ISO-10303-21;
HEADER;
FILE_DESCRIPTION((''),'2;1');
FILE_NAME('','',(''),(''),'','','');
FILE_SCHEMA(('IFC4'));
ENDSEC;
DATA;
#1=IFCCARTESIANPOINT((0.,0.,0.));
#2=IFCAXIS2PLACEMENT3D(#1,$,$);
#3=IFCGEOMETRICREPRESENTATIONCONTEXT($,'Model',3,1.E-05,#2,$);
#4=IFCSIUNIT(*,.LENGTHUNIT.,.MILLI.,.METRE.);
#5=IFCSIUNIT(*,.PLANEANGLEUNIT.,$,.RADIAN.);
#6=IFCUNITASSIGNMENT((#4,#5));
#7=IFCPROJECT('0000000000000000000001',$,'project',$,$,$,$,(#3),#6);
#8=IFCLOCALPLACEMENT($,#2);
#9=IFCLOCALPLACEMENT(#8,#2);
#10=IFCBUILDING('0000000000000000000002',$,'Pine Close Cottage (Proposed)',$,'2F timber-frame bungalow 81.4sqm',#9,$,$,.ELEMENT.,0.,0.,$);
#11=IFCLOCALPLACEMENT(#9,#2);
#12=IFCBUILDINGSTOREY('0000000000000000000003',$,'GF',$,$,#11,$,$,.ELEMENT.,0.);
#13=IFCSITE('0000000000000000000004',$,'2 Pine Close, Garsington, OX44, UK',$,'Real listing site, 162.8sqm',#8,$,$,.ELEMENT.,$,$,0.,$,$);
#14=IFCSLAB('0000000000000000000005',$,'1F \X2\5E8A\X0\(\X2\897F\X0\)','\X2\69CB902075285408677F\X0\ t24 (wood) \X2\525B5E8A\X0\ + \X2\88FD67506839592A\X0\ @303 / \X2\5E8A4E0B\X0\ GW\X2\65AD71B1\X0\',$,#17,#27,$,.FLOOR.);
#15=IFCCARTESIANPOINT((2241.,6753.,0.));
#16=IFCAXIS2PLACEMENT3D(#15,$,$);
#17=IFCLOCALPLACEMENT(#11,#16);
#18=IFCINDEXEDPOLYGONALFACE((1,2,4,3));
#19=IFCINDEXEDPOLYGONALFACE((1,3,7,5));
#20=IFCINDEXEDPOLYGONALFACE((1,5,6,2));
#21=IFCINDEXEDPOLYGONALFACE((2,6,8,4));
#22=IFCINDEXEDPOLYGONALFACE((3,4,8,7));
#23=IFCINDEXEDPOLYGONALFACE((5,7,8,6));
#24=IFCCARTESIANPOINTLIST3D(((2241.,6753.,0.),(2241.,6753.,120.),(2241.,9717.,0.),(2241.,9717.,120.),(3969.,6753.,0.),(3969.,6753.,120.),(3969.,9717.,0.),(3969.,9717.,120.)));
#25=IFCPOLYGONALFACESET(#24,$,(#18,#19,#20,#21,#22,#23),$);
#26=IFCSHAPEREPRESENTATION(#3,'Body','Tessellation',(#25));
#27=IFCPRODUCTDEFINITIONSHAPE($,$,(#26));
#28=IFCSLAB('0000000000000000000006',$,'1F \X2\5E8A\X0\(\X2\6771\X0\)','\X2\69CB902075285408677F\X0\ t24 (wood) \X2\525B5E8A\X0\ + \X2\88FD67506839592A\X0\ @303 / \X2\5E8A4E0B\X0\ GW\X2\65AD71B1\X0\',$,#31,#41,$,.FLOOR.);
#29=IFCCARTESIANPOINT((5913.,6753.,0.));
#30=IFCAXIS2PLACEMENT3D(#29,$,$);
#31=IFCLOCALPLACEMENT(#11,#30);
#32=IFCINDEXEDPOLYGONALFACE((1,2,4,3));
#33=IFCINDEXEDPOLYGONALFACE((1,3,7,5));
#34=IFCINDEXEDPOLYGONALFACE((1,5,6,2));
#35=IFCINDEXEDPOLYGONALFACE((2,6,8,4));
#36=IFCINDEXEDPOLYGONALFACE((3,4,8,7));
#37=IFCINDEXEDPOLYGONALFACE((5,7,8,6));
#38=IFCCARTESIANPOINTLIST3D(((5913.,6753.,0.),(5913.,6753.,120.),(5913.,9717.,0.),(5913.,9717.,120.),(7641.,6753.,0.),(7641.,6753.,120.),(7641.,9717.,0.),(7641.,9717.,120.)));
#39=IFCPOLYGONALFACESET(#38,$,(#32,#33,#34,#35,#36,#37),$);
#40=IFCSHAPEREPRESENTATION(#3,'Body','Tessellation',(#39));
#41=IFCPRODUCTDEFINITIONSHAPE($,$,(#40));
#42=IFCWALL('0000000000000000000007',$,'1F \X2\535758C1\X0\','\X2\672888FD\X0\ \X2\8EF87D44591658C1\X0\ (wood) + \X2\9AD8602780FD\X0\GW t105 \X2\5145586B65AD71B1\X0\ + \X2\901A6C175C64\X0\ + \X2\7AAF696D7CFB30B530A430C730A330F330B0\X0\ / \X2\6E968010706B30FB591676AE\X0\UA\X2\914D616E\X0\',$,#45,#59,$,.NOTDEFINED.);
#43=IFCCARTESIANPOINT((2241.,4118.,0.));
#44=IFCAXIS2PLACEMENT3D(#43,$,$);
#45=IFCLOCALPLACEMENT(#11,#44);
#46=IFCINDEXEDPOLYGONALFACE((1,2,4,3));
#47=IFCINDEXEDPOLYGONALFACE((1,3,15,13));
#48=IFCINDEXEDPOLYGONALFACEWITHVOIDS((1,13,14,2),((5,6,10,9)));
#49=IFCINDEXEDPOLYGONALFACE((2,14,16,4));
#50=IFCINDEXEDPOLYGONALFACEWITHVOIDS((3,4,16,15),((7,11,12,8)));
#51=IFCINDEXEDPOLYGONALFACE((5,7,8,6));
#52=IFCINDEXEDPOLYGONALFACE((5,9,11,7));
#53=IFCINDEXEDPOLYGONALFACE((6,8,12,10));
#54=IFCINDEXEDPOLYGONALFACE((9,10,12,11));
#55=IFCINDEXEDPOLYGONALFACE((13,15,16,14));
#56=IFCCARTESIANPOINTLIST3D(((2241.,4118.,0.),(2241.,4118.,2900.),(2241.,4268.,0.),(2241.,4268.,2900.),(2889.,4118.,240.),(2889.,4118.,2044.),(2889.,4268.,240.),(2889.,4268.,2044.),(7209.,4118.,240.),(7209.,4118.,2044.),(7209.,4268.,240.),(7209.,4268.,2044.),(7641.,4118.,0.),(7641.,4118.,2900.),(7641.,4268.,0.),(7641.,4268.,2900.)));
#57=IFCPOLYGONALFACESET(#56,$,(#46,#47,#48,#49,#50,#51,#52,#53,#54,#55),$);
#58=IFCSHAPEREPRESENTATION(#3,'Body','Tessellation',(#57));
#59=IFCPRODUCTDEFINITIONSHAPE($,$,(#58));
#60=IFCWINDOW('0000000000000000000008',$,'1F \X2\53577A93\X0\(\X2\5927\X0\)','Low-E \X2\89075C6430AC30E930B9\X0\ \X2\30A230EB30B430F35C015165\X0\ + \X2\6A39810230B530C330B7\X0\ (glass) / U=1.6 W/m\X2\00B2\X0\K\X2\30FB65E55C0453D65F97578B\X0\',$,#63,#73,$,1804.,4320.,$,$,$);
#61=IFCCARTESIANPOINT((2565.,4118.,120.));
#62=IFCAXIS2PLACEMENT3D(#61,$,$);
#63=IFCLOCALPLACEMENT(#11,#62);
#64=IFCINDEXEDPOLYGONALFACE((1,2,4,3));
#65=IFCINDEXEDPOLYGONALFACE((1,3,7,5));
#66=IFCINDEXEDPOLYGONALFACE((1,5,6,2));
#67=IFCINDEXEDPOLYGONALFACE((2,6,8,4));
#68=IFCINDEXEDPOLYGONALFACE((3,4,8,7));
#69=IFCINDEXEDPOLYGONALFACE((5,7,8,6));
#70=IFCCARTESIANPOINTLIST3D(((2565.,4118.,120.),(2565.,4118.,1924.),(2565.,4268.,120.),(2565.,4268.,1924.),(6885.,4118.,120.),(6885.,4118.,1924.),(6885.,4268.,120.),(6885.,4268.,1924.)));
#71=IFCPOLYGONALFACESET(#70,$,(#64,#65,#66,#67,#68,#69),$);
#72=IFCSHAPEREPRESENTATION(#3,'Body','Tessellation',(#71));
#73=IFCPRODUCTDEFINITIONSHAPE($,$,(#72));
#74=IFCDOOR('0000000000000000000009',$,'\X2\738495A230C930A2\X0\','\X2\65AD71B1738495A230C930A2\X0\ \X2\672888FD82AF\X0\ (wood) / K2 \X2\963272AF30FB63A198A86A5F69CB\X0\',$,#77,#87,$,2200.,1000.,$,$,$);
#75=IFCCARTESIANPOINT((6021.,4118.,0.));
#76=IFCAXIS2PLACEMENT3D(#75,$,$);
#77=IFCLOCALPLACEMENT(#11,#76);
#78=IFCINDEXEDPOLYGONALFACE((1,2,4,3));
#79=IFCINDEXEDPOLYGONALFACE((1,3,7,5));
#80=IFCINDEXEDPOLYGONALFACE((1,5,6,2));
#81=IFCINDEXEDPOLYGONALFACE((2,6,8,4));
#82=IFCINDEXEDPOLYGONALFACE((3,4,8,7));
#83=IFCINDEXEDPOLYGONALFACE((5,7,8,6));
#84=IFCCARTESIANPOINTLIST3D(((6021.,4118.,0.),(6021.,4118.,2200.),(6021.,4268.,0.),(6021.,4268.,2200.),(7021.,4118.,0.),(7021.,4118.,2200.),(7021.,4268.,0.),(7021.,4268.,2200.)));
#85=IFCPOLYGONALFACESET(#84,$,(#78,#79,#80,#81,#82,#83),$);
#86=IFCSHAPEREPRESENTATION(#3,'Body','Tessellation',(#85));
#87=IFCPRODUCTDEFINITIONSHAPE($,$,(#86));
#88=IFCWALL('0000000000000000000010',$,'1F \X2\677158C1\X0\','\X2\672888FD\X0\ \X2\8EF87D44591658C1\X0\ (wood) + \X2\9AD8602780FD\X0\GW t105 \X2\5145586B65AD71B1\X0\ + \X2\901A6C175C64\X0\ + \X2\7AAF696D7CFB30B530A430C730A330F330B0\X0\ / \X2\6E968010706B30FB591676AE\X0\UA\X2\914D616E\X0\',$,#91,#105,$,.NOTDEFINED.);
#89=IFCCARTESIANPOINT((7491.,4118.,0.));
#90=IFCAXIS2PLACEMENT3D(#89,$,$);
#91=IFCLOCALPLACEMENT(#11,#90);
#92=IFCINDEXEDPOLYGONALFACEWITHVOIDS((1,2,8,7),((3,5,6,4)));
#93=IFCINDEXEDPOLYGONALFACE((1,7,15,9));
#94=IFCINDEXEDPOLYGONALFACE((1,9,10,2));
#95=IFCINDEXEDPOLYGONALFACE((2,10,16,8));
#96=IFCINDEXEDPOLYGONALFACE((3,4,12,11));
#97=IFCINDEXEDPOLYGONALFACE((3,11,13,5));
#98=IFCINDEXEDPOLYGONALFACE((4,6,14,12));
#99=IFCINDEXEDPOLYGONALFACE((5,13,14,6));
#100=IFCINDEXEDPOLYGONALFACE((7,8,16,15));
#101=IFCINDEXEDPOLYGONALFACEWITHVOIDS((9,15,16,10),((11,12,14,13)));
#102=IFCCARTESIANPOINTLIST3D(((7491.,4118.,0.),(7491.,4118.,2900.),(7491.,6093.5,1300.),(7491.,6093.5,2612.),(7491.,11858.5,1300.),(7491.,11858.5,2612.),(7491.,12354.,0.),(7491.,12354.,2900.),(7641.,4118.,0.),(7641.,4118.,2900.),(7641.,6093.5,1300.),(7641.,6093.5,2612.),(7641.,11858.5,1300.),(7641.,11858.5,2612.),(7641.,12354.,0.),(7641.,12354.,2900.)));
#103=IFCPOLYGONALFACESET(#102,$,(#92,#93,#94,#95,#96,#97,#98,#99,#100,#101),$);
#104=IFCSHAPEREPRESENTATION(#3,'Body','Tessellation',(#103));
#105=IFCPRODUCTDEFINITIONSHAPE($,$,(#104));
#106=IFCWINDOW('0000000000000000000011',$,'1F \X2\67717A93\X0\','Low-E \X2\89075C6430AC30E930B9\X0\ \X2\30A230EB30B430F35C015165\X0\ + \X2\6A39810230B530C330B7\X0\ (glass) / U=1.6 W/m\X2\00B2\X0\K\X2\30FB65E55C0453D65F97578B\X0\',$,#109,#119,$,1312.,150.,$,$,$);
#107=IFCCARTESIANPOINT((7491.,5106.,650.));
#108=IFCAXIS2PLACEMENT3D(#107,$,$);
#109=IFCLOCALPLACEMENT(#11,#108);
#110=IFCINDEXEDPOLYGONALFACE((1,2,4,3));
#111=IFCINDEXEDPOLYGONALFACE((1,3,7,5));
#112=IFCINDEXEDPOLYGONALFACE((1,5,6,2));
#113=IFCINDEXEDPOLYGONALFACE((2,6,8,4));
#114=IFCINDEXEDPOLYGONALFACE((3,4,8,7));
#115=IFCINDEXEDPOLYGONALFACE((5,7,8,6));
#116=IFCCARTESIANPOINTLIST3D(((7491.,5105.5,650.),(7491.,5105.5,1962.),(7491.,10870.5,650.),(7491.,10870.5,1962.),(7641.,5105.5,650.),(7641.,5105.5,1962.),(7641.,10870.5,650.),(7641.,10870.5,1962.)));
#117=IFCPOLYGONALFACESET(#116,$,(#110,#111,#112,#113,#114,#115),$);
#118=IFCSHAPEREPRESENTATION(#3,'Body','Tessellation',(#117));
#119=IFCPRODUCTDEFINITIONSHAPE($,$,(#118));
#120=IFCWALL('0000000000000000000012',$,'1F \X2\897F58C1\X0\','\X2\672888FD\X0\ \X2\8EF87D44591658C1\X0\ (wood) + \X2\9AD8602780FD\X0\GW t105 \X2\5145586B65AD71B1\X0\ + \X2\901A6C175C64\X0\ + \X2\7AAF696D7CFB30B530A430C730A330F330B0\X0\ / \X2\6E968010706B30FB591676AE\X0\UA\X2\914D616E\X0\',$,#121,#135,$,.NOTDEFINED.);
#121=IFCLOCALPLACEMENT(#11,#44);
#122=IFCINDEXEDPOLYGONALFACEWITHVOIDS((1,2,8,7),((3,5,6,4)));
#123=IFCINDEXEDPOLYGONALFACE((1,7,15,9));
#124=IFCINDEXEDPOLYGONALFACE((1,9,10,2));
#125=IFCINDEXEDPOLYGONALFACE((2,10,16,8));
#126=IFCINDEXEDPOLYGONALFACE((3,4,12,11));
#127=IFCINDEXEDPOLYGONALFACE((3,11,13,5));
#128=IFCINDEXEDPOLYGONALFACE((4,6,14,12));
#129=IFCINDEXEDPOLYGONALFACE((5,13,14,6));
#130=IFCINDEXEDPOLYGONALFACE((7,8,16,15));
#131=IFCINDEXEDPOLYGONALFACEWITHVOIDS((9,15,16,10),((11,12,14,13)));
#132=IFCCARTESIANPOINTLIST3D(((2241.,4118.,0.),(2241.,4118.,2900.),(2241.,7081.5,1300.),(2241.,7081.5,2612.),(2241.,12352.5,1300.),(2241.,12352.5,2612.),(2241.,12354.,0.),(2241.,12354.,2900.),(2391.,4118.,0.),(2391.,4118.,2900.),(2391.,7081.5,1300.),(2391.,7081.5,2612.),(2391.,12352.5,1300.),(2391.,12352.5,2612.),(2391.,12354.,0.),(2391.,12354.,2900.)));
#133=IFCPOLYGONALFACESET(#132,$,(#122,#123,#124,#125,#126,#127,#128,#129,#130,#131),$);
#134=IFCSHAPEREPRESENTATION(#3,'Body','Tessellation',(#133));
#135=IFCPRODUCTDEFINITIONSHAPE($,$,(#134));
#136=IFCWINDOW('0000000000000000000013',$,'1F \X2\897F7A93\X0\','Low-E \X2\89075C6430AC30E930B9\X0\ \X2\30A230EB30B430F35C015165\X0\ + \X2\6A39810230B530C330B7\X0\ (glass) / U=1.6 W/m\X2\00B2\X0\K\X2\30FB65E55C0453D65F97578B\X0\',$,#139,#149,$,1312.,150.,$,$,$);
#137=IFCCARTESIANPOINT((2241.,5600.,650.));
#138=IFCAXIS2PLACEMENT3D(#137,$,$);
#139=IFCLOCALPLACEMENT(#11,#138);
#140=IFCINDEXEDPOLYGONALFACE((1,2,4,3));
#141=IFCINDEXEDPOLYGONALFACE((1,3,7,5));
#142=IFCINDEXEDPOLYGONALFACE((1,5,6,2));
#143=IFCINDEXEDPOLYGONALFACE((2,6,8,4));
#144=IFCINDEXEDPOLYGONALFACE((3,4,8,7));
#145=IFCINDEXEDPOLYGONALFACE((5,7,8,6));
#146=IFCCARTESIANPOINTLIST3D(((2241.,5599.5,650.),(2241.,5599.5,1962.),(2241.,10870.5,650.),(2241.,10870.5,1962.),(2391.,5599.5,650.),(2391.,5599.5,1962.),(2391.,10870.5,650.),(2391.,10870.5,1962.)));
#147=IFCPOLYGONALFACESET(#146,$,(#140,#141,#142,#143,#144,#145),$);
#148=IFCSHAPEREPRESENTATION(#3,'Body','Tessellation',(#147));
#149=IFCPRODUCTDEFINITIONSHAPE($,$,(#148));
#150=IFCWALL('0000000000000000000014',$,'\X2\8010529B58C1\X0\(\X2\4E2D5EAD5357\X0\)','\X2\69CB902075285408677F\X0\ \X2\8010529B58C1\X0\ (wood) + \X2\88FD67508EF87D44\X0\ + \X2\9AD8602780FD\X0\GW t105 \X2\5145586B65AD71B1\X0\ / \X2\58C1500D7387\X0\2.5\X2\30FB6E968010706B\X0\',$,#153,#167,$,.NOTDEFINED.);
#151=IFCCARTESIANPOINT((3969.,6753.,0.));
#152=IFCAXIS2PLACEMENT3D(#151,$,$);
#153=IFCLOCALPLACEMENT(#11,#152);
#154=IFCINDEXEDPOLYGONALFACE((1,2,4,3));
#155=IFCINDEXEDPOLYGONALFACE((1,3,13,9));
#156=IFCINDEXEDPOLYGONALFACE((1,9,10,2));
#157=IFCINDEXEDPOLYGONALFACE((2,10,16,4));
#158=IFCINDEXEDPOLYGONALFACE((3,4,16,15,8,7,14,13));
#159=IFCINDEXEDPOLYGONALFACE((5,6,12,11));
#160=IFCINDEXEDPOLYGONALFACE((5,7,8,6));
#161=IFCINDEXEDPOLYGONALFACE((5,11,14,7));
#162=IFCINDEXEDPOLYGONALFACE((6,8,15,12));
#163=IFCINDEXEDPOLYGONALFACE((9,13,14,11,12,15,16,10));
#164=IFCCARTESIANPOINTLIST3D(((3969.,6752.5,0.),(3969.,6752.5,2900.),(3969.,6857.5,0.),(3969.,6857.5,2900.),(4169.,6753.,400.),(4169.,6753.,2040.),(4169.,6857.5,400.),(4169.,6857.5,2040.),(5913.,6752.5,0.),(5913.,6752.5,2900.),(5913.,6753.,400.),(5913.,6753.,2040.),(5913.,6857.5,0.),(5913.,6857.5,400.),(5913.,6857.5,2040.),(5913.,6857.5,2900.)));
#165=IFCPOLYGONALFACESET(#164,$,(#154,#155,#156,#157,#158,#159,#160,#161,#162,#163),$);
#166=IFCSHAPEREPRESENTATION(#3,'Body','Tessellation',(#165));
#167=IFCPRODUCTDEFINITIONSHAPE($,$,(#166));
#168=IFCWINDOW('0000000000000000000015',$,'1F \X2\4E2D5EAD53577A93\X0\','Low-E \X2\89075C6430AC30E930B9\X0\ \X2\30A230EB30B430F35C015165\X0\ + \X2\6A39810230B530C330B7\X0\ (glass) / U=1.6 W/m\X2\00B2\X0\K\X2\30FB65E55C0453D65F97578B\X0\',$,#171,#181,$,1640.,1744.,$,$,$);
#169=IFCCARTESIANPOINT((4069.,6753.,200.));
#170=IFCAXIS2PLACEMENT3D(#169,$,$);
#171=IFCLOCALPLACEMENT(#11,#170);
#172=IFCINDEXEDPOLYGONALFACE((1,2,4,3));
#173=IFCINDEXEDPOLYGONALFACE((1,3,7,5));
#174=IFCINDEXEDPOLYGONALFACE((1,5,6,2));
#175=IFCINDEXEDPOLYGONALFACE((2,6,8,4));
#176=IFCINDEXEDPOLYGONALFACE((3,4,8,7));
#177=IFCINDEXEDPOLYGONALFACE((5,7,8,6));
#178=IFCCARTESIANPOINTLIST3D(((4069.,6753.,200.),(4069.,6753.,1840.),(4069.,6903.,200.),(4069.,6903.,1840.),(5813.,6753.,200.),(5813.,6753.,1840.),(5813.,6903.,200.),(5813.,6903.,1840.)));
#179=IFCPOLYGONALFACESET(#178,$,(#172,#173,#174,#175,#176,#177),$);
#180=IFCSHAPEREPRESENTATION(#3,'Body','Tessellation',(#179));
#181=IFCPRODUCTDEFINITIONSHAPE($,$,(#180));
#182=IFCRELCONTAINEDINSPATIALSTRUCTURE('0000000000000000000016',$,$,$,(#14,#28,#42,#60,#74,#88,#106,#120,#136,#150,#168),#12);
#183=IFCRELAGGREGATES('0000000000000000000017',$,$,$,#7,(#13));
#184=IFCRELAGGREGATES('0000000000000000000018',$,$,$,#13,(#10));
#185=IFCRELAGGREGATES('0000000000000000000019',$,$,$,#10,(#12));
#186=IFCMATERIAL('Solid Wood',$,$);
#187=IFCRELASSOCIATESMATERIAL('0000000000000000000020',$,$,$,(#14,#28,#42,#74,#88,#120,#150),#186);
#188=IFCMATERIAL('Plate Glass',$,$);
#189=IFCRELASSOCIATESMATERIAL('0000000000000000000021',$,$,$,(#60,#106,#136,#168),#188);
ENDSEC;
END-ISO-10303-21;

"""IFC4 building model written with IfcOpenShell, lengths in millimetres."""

from ifc_helpers import new_model, si_unit, frame, frame_2d, origin, place, context, project, spatial, rectangle, extrude, material, element, fill, save


model = new_model("IFC4")

# Units and contexts
model_context = context("Model", 3, precision=1e-05, world=origin())
ifc_project = project(units=[si_unit("LENGTHUNIT", "METRE", prefix="MILLI"), si_unit("PLANEANGLEUNIT", "RADIAN")], contexts=[model_context])

# Site, building, storey
site_placement = place(None, origin())
site = spatial("IfcSite", under=ifc_project, at=site_placement, Name="2 Pine Close, Garsington, OX44, UK", ObjectType="Real listing site, 162.8sqm", CompositionType="ELEMENT", RefElevation=0.0)
building_placement = place(site_placement, origin())
building = spatial("IfcBuilding", under=site, at=building_placement, Name="Pine Close Cottage (Proposed)", ObjectType="2F timber-frame bungalow 81.4sqm", CompositionType="ELEMENT", ElevationOfRefHeight=0.0, ElevationOfTerrain=0.0)
storey_placement = place(building_placement, origin())
storey = spatial("IfcBuildingStorey", under=building, at=storey_placement, Name="GF", CompositionType="ELEMENT", Elevation=0.0)

# Slabs
ifc_material_1 = material(Name="Solid Wood")
slab_1_placement = place(storey_placement, frame((2241.0, 6753.0, 0.0)))
element("IfcSlab", 1, at=slab_1_placement, inside=storey, material=ifc_material_1, Name="1F 床(西)", Description="構造用合板 t24 (wood) 剛床 + 製材根太 @303 / 床下 GW断熱", PredefinedType="FLOOR", context=model_context, shape_type="SweptSolid", body=[
    extrude(rectangle(XDim=1728.0, YDim=2964.0, at=frame_2d((864.0, 1482.0))), frame((2241.0, 6753.0, 0.0)), (0.0, 0.0, 1.0), 120.0),
])
slab_2_placement = place(storey_placement, frame((5913.0, 6753.0, 0.0)))
element("IfcSlab", 2, at=slab_2_placement, inside=storey, material=ifc_material_1, Name="1F 床(東)", Description="構造用合板 t24 (wood) 剛床 + 製材根太 @303 / 床下 GW断熱", PredefinedType="FLOOR", context=model_context, shape_type="SweptSolid", body=[
    extrude(rectangle(XDim=1728.0, YDim=2964.0, at=frame_2d((864.0, 1482.0))), frame((5913.0, 6753.0, 0.0)), (0.0, 0.0, 1.0), 120.0),
])

# Wall, openings, window, door
wall_1_placement = place(storey_placement, frame((2241.0, 4118.0, 0.0)))
wall_1 = element("IfcWall", 3, at=wall_1_placement, inside=storey, material=ifc_material_1, Name="1F 南壁", Description="木製 軸組外壁 (wood) + 高性能GW t105 充填断熱 + 通気層 + 窯業系サイディング / 準耐火・外皮UA配慮", PredefinedType="NOTDEFINED", context=model_context, shape_type="SweptSolid", body=[
    extrude(rectangle(XDim=5400.0, YDim=150.0, at=frame_2d((2700.0, 75.0))), frame((2241.0, 4118.0, 0.0)), (0.0, 0.0, 1.0), 2900.0),
])
opening_1_placement = place(storey_placement, frame((2565.0, 4118.0, 120.0)))
opening_1 = element("IfcOpeningElement", 4, at=opening_1_placement, cuts=wall_1, PredefinedType="NOTDEFINED", context=model_context, shape_type="SweptSolid", body=[
    extrude(rectangle(XDim=4320.0, YDim=150.0, at=frame_2d((2160.0, 75.0))), frame((2565.0, 4118.0, 120.0)), (0.0, 0.0, 1.0), 1804.0),
])
opening_2_placement = place(storey_placement, frame((6021.0, 4118.0, 0.0)))
opening_2 = element("IfcOpeningElement", 5, at=opening_2_placement, cuts=wall_1, PredefinedType="NOTDEFINED", context=model_context, shape_type="SweptSolid", body=[
    extrude(rectangle(XDim=1000.0, YDim=150.0, at=frame_2d((500.0, 75.0))), frame((6021.0, 4118.0, 0.0)), (0.0, 0.0, 1.0), 2200.0),
])
ifc_material_2 = material(Name="Plate Glass")
window_1_placement = place(storey_placement, frame((2565.0, 4118.0, 120.0)))
window_1 = element("IfcWindow", 6, at=window_1_placement, inside=storey, material=ifc_material_2, Name="1F 南窓(大)", Description="Low-E 複層ガラス アルゴン封入 + 樹脂サッシ (glass) / U=1.6 W/m²K・日射取得型", OverallHeight=1804.0, OverallWidth=4320.0, context=model_context, shape_type="SweptSolid", body=[
    extrude(rectangle(XDim=4320.0, YDim=150.0, at=frame_2d((2160.0, 75.0))), frame((2565.0, 4118.0, 120.0)), (0.0, 0.0, 1.0), 1804.0),
])
fill(opening_1, window_1)
door_placement = place(storey_placement, frame((6021.0, 4118.0, 0.0)))
door = element("IfcDoor", 7, at=door_placement, inside=storey, material=ifc_material_1, Name="玄関ドア", Description="断熱玄関ドア 木製芯 (wood) / K2 防犯・採風機構", OverallHeight=2200.0, OverallWidth=1000.0, context=model_context, shape_type="SweptSolid", body=[
    extrude(rectangle(XDim=1000.0, YDim=150.0, at=frame_2d((500.0, 75.0))), frame((6021.0, 4118.0, 0.0)), (0.0, 0.0, 1.0), 2200.0),
])
fill(opening_2, door)

# Walls, openings, windows
wall_2_placement = place(storey_placement, frame((7491.0, 4118.0, 0.0)))
wall_2 = element("IfcWall", 8, at=wall_2_placement, inside=storey, material=ifc_material_1, Name="1F 東壁", Description="木製 軸組外壁 (wood) + 高性能GW t105 充填断熱 + 通気層 + 窯業系サイディング / 準耐火・外皮UA配慮", PredefinedType="NOTDEFINED", context=model_context, shape_type="SweptSolid", body=[
    extrude(rectangle(XDim=150.0, YDim=8236.0, at=frame_2d((75.0, 4118.0))), frame((7491.0, 4118.0, 0.0)), (0.0, 0.0, 1.0), 2900.0),
])
opening_3_placement = place(storey_placement, frame((7491.0, 5106.0, 650.0)))
opening_3 = element("IfcOpeningElement", 9, at=opening_3_placement, cuts=wall_2, PredefinedType="NOTDEFINED", context=model_context, shape_type="SweptSolid", body=[
    extrude(rectangle(XDim=150.0, YDim=5765.0, at=frame_2d((75.0, 2882.0))), frame((7491.0, 5106.0, 650.0)), (0.0, 0.0, 1.0), 1312.0),
])
window_2_placement = place(storey_placement, frame((7491.0, 5106.0, 650.0)))
window_2 = element("IfcWindow", 10, at=window_2_placement, inside=storey, material=ifc_material_2, Name="1F 東窓", Description="Low-E 複層ガラス アルゴン封入 + 樹脂サッシ (glass) / U=1.6 W/m²K・日射取得型", OverallHeight=1312.0, OverallWidth=150.0, context=model_context, shape_type="SweptSolid", body=[
    extrude(rectangle(XDim=150.0, YDim=5765.0, at=frame_2d((75.0, 2882.0))), frame((7491.0, 5106.0, 650.0)), (0.0, 0.0, 1.0), 1312.0),
])
fill(opening_3, window_2)
wall_3_placement = place(storey_placement, frame((2241.0, 4118.0, 0.0)))
wall_3 = element("IfcWall", 11, at=wall_3_placement, inside=storey, material=ifc_material_1, Name="1F 西壁", Description="木製 軸組外壁 (wood) + 高性能GW t105 充填断熱 + 通気層 + 窯業系サイディング / 準耐火・外皮UA配慮", PredefinedType="NOTDEFINED", context=model_context, shape_type="SweptSolid", body=[
    extrude(rectangle(XDim=150.0, YDim=8236.0, at=frame_2d((75.0, 4118.0))), frame((2241.0, 4118.0, 0.0)), (0.0, 0.0, 1.0), 2900.0),
])
opening_4_placement = place(storey_placement, frame((2241.0, 5600.0, 650.0)))
opening_4 = element("IfcOpeningElement", 12, at=opening_4_placement, cuts=wall_3, PredefinedType="NOTDEFINED", context=model_context, shape_type="SweptSolid", body=[
    extrude(rectangle(XDim=150.0, YDim=5271.0, at=frame_2d((75.0, 2635.0))), frame((2241.0, 5600.0, 650.0)), (0.0, 0.0, 1.0), 1312.0),
])
window_3_placement = place(storey_placement, frame((2241.0, 5600.0, 650.0)))
window_3 = element("IfcWindow", 13, at=window_3_placement, inside=storey, material=ifc_material_2, Name="1F 西窓", Description="Low-E 複層ガラス アルゴン封入 + 樹脂サッシ (glass) / U=1.6 W/m²K・日射取得型", OverallHeight=1312.0, OverallWidth=150.0, context=model_context, shape_type="SweptSolid", body=[
    extrude(rectangle(XDim=150.0, YDim=5271.0, at=frame_2d((75.0, 2635.0))), frame((2241.0, 5600.0, 650.0)), (0.0, 0.0, 1.0), 1312.0),
])
fill(opening_4, window_3)
wall_4_placement = place(storey_placement, frame((3969.0, 6753.0, 0.0)))
wall_4 = element("IfcWall", 14, at=wall_4_placement, inside=storey, material=ifc_material_1, Name="耐力壁(中庭南)", Description="構造用合板 耐力壁 (wood) + 製材軸組 + 高性能GW t105 充填断熱 / 壁倍率2.5・準耐火", PredefinedType="NOTDEFINED", context=model_context, shape_type="SweptSolid", body=[
    extrude(rectangle(XDim=1944.0, YDim=105.0, at=frame_2d((972.0, 52.0))), frame((3969.0, 6753.0, 0.0)), (0.0, 0.0, 1.0), 2900.0),
])
opening_5_placement = place(storey_placement, frame((4069.0, 6753.0, 200.0)))
opening_5 = element("IfcOpeningElement", 15, at=opening_5_placement, cuts=wall_4, PredefinedType="NOTDEFINED", context=model_context, shape_type="SweptSolid", body=[
    extrude(rectangle(XDim=1744.0, YDim=150.0, at=frame_2d((872.0, 75.0))), frame((4069.0, 6753.0, 200.0)), (0.0, 0.0, 1.0), 1640.0),
])
window_4_placement = place(storey_placement, frame((4069.0, 6753.0, 200.0)))
window_4 = element("IfcWindow", 16, at=window_4_placement, inside=storey, material=ifc_material_2, Name="1F 中庭南窓", Description="Low-E 複層ガラス アルゴン封入 + 樹脂サッシ (glass) / U=1.6 W/m²K・日射取得型", OverallHeight=1640.0, OverallWidth=1744.0, context=model_context, shape_type="SweptSolid", body=[
    extrude(rectangle(XDim=1744.0, YDim=150.0, at=frame_2d((872.0, 75.0))), frame((4069.0, 6753.0, 200.0)), (0.0, 0.0, 1.0), 1640.0),
])
fill(opening_5, window_4)

save(model, "model.ifc")
